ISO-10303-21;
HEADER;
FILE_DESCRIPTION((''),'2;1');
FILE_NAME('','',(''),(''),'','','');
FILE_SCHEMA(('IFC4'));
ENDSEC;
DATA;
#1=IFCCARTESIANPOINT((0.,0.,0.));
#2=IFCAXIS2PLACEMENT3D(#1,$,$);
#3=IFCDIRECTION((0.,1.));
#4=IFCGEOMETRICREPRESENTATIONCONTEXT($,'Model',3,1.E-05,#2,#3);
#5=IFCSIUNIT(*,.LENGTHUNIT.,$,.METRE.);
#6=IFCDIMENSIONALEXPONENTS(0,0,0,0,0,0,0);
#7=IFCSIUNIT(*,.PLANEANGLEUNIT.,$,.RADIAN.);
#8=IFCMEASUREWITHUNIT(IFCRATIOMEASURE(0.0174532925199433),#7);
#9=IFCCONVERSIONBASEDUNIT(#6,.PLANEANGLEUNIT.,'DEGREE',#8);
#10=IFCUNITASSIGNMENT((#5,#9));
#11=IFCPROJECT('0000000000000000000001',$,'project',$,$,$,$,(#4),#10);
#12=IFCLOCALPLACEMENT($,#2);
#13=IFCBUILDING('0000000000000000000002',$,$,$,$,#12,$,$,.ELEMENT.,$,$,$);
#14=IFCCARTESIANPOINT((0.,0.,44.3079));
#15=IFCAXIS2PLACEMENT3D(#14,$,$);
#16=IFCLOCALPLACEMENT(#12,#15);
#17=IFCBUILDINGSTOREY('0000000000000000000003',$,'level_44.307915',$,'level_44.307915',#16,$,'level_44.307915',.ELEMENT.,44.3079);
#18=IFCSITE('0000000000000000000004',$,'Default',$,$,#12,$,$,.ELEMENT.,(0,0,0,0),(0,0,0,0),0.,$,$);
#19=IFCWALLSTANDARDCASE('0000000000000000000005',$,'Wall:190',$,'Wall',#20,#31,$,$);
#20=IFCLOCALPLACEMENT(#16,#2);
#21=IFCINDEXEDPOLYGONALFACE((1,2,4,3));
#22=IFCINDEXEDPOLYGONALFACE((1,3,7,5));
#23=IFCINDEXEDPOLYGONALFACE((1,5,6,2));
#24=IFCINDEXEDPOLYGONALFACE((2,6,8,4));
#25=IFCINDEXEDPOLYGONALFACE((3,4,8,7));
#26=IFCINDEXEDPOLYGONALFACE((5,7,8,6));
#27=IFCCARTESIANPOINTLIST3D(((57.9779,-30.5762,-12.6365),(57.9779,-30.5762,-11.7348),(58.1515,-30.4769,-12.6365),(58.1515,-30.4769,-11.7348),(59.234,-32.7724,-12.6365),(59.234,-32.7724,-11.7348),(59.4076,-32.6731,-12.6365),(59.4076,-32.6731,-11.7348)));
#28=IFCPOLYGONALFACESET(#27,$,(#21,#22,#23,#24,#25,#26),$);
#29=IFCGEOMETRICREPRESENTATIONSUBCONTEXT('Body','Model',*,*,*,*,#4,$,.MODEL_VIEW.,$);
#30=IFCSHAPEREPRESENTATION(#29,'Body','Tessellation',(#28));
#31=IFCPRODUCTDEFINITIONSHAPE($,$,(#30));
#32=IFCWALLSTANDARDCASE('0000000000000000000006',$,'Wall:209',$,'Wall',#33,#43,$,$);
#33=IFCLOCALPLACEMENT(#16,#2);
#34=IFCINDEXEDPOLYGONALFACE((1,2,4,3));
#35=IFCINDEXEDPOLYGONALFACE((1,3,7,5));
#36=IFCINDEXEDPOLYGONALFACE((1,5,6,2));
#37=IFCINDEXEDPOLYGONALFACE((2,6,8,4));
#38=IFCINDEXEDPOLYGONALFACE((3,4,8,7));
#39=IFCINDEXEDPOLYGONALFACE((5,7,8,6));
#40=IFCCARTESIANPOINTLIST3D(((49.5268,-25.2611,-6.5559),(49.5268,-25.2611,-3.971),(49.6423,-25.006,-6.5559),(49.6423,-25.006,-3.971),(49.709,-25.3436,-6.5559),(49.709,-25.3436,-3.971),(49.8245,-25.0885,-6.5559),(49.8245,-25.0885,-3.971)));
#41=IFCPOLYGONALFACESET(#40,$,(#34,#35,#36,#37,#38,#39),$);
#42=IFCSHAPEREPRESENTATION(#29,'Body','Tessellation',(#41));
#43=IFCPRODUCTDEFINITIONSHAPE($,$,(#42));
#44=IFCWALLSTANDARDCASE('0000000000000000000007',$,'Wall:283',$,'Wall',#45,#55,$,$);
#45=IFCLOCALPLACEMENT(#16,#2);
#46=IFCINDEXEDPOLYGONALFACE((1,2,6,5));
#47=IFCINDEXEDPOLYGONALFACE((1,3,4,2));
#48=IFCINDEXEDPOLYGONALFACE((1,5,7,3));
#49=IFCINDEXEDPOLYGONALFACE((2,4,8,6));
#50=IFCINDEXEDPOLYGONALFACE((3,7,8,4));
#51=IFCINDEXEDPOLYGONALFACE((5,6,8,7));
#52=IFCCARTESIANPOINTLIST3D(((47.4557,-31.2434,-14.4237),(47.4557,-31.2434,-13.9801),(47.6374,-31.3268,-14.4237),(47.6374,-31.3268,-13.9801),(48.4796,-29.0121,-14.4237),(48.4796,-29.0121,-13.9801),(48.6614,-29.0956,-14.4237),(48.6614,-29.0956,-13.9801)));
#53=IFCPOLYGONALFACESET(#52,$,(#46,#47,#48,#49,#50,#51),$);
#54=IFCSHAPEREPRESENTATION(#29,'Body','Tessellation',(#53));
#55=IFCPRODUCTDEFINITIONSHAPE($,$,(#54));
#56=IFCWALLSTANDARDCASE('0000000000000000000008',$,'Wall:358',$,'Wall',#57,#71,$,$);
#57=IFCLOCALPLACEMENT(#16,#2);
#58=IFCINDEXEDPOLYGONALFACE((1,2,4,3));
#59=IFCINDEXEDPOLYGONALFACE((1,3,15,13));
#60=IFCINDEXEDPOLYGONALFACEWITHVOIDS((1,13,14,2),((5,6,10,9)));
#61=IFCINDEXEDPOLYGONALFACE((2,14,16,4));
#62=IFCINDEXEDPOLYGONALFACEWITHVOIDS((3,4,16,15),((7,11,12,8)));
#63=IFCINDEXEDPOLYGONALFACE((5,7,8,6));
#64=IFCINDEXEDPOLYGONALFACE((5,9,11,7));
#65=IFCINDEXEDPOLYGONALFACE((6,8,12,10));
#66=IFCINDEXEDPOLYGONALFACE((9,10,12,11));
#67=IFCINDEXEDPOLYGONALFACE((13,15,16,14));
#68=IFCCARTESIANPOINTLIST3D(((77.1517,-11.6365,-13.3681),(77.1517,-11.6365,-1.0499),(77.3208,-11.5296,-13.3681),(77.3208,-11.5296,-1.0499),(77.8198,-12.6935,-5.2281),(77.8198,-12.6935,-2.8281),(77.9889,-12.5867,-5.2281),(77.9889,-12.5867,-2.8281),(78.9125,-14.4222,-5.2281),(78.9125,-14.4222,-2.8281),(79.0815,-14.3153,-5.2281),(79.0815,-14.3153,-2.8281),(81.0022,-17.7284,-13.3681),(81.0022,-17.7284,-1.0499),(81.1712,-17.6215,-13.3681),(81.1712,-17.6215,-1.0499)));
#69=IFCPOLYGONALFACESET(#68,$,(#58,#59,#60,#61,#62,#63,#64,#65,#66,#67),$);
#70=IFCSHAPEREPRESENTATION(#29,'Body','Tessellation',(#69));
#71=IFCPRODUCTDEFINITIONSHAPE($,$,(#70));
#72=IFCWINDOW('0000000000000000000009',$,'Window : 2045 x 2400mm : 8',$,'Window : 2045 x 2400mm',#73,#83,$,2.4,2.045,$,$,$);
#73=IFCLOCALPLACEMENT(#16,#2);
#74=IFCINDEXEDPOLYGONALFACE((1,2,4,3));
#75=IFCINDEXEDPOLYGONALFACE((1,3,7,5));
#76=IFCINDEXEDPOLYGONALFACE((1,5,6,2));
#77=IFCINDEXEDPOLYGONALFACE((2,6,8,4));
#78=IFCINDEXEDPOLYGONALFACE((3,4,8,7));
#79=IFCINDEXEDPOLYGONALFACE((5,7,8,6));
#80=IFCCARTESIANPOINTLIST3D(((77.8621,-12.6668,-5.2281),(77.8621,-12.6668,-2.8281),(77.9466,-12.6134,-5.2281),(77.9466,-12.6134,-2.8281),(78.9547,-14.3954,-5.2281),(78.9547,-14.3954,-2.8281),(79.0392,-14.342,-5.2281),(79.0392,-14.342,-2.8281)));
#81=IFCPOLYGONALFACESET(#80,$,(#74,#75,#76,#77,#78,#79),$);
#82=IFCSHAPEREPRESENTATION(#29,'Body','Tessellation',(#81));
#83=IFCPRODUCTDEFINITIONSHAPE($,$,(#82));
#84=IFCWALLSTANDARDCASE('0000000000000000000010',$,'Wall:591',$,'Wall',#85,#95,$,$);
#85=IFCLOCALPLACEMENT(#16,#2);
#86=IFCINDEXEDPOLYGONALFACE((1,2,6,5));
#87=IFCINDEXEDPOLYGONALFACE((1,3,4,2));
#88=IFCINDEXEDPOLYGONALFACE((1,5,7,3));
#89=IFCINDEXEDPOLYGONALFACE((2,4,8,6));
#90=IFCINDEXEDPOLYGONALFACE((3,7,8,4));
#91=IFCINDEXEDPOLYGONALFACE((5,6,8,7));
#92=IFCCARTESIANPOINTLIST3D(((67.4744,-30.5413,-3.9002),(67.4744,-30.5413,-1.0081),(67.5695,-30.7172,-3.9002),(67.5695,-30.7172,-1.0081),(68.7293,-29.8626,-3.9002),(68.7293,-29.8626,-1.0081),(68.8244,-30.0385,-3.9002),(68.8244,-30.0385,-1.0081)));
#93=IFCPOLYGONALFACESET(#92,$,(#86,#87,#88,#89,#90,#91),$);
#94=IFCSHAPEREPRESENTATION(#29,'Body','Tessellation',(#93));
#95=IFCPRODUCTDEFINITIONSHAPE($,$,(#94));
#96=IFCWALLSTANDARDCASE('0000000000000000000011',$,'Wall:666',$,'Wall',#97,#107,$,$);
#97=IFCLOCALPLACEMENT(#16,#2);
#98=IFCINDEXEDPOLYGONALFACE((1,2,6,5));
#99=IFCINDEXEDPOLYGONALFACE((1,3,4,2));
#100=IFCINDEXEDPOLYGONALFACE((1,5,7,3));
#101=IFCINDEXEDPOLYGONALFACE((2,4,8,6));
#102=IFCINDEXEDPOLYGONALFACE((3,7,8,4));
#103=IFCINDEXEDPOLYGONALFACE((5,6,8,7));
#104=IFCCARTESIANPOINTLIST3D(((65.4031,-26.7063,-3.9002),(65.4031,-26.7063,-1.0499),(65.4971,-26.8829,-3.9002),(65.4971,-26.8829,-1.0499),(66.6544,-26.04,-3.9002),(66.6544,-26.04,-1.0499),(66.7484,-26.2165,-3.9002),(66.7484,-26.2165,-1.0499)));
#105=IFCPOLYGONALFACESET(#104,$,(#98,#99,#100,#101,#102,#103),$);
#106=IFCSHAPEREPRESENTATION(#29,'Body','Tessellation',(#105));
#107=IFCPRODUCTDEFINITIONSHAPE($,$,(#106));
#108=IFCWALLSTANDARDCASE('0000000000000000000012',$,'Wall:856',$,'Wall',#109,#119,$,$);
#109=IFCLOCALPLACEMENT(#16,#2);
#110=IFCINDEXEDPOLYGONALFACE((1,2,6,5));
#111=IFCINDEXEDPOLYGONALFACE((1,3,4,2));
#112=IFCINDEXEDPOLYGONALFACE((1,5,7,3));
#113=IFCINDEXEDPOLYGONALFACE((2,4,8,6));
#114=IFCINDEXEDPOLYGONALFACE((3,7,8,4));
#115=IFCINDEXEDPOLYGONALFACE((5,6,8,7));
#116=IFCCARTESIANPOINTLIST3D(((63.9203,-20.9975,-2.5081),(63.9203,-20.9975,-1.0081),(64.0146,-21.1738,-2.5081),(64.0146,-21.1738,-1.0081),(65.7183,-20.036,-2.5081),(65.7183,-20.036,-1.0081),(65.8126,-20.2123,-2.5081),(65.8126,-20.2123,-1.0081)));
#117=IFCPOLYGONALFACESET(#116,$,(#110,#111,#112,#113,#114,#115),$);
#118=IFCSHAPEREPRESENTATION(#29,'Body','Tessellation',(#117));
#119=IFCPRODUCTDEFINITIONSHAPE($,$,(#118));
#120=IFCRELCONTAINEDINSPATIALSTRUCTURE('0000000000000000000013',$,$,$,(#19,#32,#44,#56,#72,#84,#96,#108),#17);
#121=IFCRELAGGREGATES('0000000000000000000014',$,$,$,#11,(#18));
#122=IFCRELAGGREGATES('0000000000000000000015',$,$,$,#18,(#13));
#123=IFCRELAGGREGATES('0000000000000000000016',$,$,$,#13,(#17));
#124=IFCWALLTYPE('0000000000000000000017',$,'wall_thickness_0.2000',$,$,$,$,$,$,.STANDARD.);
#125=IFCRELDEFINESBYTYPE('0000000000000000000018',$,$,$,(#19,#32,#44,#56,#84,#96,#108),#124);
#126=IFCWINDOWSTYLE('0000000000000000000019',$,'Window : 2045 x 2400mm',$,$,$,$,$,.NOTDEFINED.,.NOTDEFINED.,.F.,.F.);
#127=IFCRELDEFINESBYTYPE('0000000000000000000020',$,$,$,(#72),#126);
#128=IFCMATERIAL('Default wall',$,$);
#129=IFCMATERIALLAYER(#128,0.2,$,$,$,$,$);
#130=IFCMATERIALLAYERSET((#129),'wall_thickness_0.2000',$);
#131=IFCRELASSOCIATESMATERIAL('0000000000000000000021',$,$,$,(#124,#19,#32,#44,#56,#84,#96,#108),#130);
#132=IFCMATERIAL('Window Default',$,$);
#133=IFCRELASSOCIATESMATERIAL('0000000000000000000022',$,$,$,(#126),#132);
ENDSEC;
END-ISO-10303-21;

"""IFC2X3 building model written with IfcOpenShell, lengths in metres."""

from ifc_helpers import new_model, entity, si_unit, converted_unit, direction, frame, frame_2d, origin, origin_2d_with_axis, place, context, subcontext, project, spatial, polyline, rectangle, outline, extrude, source, transform, mapped, material, layer, layer_set, layer_usage, type_object, type_shapes, element, fill, save


model = new_model("IFC2X3")

# Units and contexts
model_context = context("Model", 3, precision=1e-05, world=origin(), true_north=direction((0.0, 1.0)))
body_context = subcontext(model_context, "Body", "Model", "MODEL_VIEW")
ifc_project = project(units=[si_unit("LENGTHUNIT", "METRE"), converted_unit("PLANEANGLEUNIT", "DEGREE", entity("IfcRatioMeasure", 0.0174532925199433), si_unit("PLANEANGLEUNIT", "RADIAN"), dimensions=[0, 0, 0, 0, 0, 0, 0])], contexts=[model_context])

# Site, building, storey
placement_1 = place(None, origin())
site = spatial("IfcSite", under=ifc_project, at=placement_1, Name="Default", CompositionType="ELEMENT", RefLatitude=(0, 0, 0, 0), RefLongitude=(0, 0, 0, 0), RefElevation=0.0)
building = spatial("IfcBuilding", under=site, at=placement_1, CompositionType="ELEMENT")
storey_placement = place(placement_1, frame((0.0, 0.0, 44.3079)))
storey = spatial("IfcBuildingStorey", under=building, at=storey_placement, Name="level_44.307915", ObjectType="level_44.307915", LongName="level_44.307915", CompositionType="ELEMENT", Elevation=44.3079)

# Walls
ifc_material_1 = material(Name="Default wall")
ifc_layer = layer(ifc_material_1, 0.2)
ifc_layer_set = layer_set([ifc_layer], Name="wall_thickness_0.2000")
ifc_layer_usage = layer_usage(ifc_layer_set, "AXIS2", "POSITIVE", -0.1)
wall_type = type_object("IfcWallType", Name="wall_thickness_0.2000", PredefinedType="STANDARD", material=ifc_layer_set)
placement_2 = place(placement_1, frame((0.0, 0.0, 31.6714)))
wall_1_placement = place(placement_2, frame((58.0647, -30.5266, 0.0), z_axis=(0.0, 0.0, 1.0), x_axis=(0.49648, -0.868048, 0.0)))
element("IfcWallStandardCase", 1, at=wall_1_placement, inside=storey, type_object=wall_type, material=ifc_layer_usage, Name="Wall:190", ObjectType="Wall", context=body_context, shape_type="SweptSolid", body=[
    extrude(outline(polyline([(2.53, -0.1), (2.53, 0.1), (0.0, 0.1), (0.0, -0.1), (2.53, -0.1)])), origin(), (0.0, 0.0, 1.0), 0.9017),
])
placement_3 = place(placement_1, frame((0.0, 0.0, 37.752)))
wall_2_placement = place(placement_3, frame((49.6179, -25.3023, 0.0), z_axis=(0.0, 0.0, 1.0), x_axis=(0.412466, 0.910973, 0.0)))
element("IfcWallStandardCase", 2, at=wall_2_placement, inside=storey, type_object=wall_type, material=ifc_layer_usage, Name="Wall:209", ObjectType="Wall", context=body_context, shape_type="SweptSolid", body=[
    extrude(outline(polyline([(0.28, -0.1), (0.28, 0.1), (0.0, 0.1), (0.0, -0.1), (0.28, -0.1)])), origin(), (0.0, 0.0, 1.0), 2.5849),
])
placement_4 = place(placement_1, frame((0.0, 0.0, 29.8842)))
wall_3_placement = place(placement_4, frame((47.5466, -31.2851, 0.0), z_axis=(0.0, 0.0, 1.0), x_axis=(0.417081, 0.908869, 0.0)))
element("IfcWallStandardCase", 3, at=wall_3_placement, inside=storey, type_object=wall_type, material=ifc_layer_usage, Name="Wall:283", ObjectType="Wall", context=body_context, shape_type="SweptSolid", body=[
    extrude(outline(polyline([(2.455, -0.1), (2.455, 0.1), (0.0, 0.1), (0.0, -0.1), (2.455, -0.1)])), origin(), (0.0, 0.0, 1.0), 0.4436),
])

# Wall, opening, window
placement_5 = place(placement_1, frame((0.0, 0.0, 30.9398)))
wall_4_placement = place(placement_5, frame((81.0867, -17.6749, 0.0), z_axis=(0.0, 0.0, 1.0), x_axis=(-0.534286, 0.845304, 0.0)))
wall_4 = element("IfcWallStandardCase", 4, at=wall_4_placement, inside=storey, type_object=wall_type, material=ifc_layer_usage, Name="Wall:358", ObjectType="Wall", context=body_context, shape_type="SweptSolid", body=[
    extrude(outline(polyline([(7.2067, -0.1), (7.2067, 0.1), (0.0, 0.1), (0.0, -0.1), (7.2067, -0.1)])), origin(), (0.0, 0.0, 1.0), 12.3182),
])
opening_1_placement = place(wall_4_placement, frame((3.9113, -0.1, 8.14)))
opening_1 = element("IfcOpeningElement", 5, at=opening_1_placement, cuts=wall_4, ObjectType="Opening", context=body_context, shape_type="SweptSolid", body=[
    extrude(rectangle(XDim=2.045, YDim=2.4, at=frame_2d((1.2, 1.0225), x_axis=(0.0, 1.0))), frame((0.0, 0.0, 0.0), z_axis=(0.0, 1.0, 0.0), x_axis=(0.0, 0.0, 1.0)), (0.0, 0.0, 1.0), 0.2),
])
ifc_material_2 = material(Name="Window Default")
window_style_1 = type_object("IfcWindowStyle", Name="Window : 2045 x 2400mm", ConstructionType="NOTDEFINED", OperationType="NOTDEFINED", ParameterTakesPrecedence=False, Sizeable=False, material=ifc_material_2)
shared_shape_1 = source(origin(), body_context, "Body", "SweptSolid", [
    extrude(rectangle(XDim=0.1, YDim=2.045, at=origin_2d_with_axis()), frame((1.0225, 0.1, 0.0), z_axis=(0.0, 0.0, 1.0), x_axis=(0.0, 1.0, 0.0)), (0.0, 0.0, 1.0), 2.4),
])
type_shapes(window_style_1, [shared_shape_1])
window_1_placement = place(opening_1_placement, origin())
window_1 = element("IfcWindow", 6, at=window_1_placement, inside=storey, type_object=window_style_1, Name="Window : 2045 x 2400mm : 8", ObjectType="Window : 2045 x 2400mm", OverallHeight=2.4, OverallWidth=2.045, context=body_context, shape_type="MappedRepresentation", body=[
    mapped(shared_shape_1, transform((0.0, 0.0, 0.0), scale=1.0)),
])
fill(opening_1, window_1)

# Walls
placement_6 = place(placement_1, frame((0.0, 0.0, 40.4077)))
wall_5_placement = place(placement_6, frame((68.7768, -29.9506, 0.0), z_axis=(0.0, 0.0, 1.0), x_axis=(-0.879602, -0.47571, 0.0)))
element("IfcWallStandardCase", 7, at=wall_5_placement, inside=storey, type_object=wall_type, material=ifc_layer_usage, Name="Wall:591", ObjectType="Wall", context=body_context, shape_type="SweptSolid", body=[
    extrude(outline(polyline([(1.4267, -0.1), (1.4267, 0.1), (0.0, 0.1), (0.0, -0.1), (1.4267, -0.1)])), origin(), (0.0, 0.0, 1.0), 2.8921),
])
placement_7 = place(placement_1, frame((0.0, 0.0, 40.4077)))
wall_6_placement = place(placement_7, frame((66.7014, -26.1283, 0.0), z_axis=(0.0, 0.0, 1.0), x_axis=(-0.882647, -0.470036, 0.0)))
element("IfcWallStandardCase", 8, at=wall_6_placement, inside=storey, type_object=wall_type, material=ifc_layer_usage, Name="Wall:666", ObjectType="Wall", context=body_context, shape_type="SweptSolid", body=[
    extrude(outline(polyline([(1.4176, -0.1), (1.4176, 0.1), (0.0, 0.1), (0.0, -0.1), (1.4176, -0.1)])), origin(), (0.0, 0.0, 1.0), 2.8503),
])
placement_8 = place(placement_1, frame((0.0, 0.0, 41.7998)))
wall_7_placement = place(placement_8, frame((63.9675, -21.0856, 0.0), z_axis=(0.0, 0.0, 1.0), x_axis=(0.881832, 0.471565, 0.0)))
element("IfcWallStandardCase", 9, at=wall_7_placement, inside=storey, type_object=wall_type, material=ifc_layer_usage, Name="Wall:856", ObjectType="Wall", context=body_context, shape_type="SweptSolid", body=[
    extrude(outline(polyline([(2.0389, -0.1), (2.0389, 0.1), (0.0, 0.1), (0.0, -0.1), (2.0389, -0.1)])), origin(), (0.0, 0.0, 1.0), 1.5),
])

save(model, "model.ifc")
